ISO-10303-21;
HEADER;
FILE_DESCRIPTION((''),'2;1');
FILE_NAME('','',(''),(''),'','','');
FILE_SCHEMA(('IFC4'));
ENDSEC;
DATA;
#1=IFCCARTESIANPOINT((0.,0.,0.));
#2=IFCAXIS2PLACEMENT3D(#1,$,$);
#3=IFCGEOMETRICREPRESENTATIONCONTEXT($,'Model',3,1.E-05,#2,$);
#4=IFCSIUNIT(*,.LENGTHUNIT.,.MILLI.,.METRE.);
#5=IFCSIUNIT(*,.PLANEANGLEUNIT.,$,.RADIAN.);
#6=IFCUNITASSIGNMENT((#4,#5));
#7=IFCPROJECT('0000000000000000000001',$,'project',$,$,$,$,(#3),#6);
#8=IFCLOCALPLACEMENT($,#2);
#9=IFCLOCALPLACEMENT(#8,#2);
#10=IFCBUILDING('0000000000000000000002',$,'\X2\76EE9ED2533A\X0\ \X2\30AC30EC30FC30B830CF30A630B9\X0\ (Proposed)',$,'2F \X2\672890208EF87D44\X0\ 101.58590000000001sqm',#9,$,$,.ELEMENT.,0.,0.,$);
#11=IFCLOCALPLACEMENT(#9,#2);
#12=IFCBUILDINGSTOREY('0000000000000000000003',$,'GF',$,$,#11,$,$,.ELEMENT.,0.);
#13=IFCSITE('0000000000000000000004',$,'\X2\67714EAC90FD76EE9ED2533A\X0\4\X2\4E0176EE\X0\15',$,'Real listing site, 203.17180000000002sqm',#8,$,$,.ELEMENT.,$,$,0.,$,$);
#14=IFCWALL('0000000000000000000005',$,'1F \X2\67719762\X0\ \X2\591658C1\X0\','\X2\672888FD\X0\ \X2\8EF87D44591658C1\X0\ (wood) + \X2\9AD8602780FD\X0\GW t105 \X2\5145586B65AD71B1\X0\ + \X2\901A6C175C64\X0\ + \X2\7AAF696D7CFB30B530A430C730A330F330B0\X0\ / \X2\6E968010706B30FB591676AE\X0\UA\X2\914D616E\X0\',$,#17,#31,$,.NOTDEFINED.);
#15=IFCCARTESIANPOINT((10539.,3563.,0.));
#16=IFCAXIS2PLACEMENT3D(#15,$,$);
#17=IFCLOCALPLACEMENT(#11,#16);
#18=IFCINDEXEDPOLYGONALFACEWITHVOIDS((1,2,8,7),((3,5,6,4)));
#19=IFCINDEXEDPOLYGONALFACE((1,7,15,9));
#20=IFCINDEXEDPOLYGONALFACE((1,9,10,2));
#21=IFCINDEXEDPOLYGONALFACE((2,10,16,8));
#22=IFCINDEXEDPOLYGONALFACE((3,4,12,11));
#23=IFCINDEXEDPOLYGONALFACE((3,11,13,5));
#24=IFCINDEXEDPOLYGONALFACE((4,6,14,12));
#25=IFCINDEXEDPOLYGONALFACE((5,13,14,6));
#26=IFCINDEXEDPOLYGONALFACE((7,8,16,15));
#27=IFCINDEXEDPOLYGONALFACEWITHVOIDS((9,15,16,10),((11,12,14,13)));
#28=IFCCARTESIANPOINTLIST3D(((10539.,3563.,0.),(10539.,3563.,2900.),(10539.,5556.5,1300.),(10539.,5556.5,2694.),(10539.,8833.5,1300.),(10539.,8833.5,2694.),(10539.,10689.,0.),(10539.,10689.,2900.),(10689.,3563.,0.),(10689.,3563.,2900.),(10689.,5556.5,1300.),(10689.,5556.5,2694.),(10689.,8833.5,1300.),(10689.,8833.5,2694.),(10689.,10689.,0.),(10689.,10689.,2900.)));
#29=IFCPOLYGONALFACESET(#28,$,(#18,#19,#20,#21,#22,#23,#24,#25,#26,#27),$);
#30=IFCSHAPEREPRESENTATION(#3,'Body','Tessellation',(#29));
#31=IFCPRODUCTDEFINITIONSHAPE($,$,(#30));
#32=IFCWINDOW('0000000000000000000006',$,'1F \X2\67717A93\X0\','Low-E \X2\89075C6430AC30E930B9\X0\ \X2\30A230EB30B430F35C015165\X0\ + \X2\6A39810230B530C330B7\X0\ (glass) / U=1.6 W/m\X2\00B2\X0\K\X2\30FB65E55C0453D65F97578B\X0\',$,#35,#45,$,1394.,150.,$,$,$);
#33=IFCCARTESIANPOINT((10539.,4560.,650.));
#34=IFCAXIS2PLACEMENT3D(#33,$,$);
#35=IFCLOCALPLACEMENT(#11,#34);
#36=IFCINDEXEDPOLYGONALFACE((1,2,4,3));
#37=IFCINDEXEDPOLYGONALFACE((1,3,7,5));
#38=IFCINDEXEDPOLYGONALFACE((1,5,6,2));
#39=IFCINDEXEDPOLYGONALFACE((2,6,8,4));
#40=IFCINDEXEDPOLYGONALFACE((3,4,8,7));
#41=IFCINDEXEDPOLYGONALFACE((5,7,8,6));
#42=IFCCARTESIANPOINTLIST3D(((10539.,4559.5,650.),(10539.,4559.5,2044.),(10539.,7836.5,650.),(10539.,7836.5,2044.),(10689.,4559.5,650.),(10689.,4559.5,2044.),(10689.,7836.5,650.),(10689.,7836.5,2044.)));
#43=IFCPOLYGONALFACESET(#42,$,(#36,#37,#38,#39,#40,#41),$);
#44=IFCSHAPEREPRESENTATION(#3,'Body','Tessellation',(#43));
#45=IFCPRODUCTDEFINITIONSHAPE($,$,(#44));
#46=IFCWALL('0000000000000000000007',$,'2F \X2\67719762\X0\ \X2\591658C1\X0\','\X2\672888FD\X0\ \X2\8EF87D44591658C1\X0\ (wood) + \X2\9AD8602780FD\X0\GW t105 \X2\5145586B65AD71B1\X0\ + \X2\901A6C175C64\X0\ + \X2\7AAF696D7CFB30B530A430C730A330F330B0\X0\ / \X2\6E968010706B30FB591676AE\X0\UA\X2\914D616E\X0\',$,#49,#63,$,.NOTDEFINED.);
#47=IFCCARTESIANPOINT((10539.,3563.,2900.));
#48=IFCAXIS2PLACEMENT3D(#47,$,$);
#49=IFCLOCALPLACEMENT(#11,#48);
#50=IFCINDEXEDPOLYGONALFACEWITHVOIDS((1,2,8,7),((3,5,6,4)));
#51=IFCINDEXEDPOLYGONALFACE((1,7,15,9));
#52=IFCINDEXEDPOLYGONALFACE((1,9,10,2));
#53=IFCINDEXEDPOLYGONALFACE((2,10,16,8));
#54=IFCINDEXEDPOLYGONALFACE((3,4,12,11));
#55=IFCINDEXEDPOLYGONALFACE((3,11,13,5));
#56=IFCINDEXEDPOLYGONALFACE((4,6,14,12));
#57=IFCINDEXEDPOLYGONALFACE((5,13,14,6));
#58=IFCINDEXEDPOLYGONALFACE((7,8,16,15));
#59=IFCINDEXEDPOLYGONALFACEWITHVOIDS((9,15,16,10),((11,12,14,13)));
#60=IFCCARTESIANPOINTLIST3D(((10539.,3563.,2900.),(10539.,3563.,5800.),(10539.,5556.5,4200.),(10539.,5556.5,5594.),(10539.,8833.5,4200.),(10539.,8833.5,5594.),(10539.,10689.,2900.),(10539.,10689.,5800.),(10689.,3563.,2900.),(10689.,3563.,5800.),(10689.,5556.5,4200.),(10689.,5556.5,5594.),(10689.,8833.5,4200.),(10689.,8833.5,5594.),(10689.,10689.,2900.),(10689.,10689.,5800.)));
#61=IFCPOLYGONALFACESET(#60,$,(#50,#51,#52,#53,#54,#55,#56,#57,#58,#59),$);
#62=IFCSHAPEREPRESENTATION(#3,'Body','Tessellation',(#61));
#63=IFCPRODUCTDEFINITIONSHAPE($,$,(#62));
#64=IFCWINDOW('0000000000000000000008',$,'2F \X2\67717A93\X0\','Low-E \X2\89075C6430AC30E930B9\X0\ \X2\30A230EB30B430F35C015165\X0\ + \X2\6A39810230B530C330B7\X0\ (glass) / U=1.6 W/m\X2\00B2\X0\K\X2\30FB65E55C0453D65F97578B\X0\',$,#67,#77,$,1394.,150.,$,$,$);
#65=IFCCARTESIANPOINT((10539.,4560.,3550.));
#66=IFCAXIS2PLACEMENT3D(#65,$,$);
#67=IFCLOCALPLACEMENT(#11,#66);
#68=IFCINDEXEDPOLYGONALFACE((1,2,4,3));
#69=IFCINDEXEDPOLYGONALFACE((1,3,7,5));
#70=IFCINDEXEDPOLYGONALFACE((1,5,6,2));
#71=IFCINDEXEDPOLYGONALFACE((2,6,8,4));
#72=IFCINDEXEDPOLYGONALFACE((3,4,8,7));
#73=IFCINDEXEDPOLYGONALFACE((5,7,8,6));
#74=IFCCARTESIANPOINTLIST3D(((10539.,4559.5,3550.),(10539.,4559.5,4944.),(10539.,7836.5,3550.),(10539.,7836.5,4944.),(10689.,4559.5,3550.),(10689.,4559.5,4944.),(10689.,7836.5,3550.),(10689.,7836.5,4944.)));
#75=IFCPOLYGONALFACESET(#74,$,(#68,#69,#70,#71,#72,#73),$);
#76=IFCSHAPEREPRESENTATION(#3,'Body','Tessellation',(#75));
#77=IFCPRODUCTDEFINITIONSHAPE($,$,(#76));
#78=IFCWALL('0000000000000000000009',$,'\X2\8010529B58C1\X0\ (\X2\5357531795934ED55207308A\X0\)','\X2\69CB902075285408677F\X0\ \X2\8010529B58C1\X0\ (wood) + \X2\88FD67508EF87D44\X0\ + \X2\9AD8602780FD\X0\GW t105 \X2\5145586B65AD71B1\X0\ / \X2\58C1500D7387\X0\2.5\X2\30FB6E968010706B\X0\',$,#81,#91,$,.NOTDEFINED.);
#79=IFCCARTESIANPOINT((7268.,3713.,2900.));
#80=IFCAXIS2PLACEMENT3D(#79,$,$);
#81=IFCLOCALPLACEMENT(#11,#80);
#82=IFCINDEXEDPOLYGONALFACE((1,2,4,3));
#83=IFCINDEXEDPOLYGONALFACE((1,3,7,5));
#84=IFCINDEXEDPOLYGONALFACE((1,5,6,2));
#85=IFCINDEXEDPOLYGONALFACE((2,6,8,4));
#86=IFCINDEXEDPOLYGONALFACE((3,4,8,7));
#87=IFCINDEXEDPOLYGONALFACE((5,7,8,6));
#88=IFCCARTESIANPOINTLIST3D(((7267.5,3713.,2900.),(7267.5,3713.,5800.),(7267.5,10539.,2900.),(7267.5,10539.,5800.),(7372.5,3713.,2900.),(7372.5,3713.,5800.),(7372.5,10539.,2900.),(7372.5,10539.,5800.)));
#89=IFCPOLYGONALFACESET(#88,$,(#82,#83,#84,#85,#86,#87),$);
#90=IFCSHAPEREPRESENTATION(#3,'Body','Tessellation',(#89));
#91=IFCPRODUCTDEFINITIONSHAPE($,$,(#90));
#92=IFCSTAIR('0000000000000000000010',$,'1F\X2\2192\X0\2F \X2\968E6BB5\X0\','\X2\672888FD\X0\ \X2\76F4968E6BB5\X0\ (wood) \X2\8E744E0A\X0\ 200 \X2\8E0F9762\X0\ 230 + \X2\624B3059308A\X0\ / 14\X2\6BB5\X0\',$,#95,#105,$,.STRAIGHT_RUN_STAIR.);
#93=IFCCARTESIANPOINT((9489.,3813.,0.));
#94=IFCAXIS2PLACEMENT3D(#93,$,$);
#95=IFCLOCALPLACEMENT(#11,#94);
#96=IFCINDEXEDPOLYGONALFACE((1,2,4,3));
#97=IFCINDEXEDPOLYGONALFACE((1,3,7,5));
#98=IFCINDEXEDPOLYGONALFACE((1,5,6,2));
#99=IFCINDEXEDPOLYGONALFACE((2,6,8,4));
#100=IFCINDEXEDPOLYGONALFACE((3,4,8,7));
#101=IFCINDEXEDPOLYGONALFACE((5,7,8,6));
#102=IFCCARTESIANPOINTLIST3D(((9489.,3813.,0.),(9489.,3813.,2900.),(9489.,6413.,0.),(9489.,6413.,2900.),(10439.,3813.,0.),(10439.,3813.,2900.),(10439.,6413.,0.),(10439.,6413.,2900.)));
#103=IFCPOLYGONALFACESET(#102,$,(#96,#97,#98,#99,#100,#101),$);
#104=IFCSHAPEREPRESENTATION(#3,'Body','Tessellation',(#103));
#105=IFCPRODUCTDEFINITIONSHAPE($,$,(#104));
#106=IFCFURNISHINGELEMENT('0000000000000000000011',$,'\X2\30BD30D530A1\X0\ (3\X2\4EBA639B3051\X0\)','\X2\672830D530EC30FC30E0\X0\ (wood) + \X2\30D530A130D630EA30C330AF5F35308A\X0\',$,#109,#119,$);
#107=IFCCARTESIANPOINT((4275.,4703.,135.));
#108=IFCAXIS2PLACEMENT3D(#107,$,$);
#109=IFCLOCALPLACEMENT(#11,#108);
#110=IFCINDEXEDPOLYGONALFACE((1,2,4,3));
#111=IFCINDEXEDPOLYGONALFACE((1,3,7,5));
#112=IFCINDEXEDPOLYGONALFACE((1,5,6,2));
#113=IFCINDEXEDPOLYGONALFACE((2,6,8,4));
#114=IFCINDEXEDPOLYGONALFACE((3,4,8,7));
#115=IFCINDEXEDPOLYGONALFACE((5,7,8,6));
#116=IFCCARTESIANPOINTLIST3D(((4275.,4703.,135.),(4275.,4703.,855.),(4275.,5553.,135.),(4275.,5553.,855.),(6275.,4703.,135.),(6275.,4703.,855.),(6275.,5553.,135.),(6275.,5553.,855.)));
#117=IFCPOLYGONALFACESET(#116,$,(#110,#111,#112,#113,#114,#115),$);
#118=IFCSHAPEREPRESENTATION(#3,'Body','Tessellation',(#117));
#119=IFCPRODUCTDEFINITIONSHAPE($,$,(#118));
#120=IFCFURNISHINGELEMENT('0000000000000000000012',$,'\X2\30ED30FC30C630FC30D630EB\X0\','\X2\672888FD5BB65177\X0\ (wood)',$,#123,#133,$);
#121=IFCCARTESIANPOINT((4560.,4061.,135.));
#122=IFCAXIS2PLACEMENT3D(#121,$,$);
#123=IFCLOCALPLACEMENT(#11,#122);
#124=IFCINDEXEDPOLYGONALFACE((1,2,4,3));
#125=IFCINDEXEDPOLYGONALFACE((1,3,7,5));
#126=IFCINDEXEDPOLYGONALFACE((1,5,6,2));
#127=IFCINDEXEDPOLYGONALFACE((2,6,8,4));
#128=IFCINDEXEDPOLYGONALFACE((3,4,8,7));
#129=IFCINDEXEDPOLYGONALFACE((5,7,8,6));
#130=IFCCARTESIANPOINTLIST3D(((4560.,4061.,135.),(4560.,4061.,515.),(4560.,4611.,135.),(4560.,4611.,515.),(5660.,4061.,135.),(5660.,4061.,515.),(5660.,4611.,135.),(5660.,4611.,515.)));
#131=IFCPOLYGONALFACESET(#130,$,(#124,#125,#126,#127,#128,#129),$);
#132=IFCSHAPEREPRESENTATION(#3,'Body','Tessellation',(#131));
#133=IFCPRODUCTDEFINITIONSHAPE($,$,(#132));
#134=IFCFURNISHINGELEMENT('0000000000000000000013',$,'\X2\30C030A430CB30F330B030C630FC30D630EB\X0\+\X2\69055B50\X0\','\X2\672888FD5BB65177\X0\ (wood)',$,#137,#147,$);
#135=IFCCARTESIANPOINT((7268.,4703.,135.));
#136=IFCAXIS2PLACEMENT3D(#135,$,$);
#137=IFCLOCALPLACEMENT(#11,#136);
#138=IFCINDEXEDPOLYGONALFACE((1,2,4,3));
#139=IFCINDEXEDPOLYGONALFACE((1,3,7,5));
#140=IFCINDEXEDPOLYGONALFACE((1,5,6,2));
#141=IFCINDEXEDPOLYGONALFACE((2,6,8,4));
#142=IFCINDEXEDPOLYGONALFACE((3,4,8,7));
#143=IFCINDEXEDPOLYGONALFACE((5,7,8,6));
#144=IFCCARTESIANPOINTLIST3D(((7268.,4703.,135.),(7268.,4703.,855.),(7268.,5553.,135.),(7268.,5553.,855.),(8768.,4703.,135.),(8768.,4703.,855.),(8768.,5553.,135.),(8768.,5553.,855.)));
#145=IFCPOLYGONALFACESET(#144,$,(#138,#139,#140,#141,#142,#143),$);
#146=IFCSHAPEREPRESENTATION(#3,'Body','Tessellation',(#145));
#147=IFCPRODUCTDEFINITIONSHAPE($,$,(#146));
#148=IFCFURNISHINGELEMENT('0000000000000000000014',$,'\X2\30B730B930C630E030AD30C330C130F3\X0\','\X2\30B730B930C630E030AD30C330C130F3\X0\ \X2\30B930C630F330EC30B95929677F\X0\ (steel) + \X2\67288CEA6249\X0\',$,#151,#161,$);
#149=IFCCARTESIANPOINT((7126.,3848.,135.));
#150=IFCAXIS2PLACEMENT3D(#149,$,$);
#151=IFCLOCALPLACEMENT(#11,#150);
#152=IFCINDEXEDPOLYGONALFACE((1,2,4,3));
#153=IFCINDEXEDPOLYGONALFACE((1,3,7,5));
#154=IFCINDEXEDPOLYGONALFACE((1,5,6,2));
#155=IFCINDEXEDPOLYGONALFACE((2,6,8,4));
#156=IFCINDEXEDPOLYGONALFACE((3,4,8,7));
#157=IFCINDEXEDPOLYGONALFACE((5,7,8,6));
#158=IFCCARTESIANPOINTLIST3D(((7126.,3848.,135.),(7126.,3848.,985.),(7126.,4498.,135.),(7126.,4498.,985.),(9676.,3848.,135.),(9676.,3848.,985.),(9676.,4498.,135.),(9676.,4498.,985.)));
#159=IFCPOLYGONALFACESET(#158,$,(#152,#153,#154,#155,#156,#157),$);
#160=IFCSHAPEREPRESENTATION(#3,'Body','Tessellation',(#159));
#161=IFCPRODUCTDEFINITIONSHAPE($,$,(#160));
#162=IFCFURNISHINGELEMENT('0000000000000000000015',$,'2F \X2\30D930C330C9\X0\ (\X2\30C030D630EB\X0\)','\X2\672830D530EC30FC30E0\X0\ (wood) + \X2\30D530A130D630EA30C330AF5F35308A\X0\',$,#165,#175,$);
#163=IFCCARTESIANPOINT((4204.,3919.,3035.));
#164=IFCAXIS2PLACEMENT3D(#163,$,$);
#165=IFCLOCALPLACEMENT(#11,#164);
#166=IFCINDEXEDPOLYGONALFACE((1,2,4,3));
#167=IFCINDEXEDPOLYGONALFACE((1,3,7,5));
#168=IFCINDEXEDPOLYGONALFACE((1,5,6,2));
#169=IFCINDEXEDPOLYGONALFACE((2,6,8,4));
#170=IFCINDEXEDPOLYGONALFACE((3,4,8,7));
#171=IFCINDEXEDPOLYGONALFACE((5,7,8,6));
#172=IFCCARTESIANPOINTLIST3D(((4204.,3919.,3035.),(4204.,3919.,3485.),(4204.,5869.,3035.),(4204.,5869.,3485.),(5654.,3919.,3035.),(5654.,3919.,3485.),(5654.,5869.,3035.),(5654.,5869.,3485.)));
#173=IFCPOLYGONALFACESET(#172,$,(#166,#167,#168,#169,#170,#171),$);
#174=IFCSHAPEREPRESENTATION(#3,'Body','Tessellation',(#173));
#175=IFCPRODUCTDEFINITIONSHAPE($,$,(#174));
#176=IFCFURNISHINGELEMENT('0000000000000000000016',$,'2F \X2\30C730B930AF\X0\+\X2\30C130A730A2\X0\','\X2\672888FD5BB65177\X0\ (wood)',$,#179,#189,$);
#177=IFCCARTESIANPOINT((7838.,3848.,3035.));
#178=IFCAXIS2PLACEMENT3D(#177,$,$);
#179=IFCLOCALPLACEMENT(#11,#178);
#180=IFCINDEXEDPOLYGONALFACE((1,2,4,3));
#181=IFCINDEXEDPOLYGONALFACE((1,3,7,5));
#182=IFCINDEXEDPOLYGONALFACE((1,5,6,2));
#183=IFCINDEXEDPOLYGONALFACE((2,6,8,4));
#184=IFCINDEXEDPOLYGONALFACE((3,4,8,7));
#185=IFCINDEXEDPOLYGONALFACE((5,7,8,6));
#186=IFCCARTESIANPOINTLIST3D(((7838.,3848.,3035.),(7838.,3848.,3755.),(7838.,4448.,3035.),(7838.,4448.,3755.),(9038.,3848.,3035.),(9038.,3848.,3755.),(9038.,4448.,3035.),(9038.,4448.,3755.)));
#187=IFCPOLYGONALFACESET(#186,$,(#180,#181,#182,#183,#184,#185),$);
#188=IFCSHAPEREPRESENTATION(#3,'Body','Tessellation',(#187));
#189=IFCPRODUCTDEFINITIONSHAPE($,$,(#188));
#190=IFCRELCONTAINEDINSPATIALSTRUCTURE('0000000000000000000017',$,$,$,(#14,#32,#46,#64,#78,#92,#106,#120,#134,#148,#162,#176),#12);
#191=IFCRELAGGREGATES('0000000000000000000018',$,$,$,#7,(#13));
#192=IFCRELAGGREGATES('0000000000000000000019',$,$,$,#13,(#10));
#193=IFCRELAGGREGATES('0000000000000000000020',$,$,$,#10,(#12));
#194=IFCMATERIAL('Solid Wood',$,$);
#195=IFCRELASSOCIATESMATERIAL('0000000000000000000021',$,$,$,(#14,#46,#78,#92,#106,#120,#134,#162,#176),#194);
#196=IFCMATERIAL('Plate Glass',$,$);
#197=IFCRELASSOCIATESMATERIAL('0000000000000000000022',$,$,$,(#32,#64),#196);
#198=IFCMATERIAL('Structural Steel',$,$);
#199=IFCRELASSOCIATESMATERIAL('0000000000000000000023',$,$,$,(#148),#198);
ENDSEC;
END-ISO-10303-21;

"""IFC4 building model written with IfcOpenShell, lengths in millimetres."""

from ifc_helpers import new_model, si_unit, frame, frame_2d, origin, place, context, project, spatial, rectangle, extrude, material, element, fill, save


model = new_model("IFC4")

# Units and contexts
model_context = context("Model", 3, precision=1e-05, world=origin())
ifc_project = project(units=[si_unit("LENGTHUNIT", "METRE", prefix="MILLI"), si_unit("PLANEANGLEUNIT", "RADIAN")], contexts=[model_context])

# Site, building, storey
site_placement = place(None, origin())
site = spatial("IfcSite", under=ifc_project, at=site_placement, Name="東京都目黒区4丁目15", ObjectType="Real listing site, 203.17180000000002sqm", CompositionType="ELEMENT", RefElevation=0.0)
building_placement = place(site_placement, origin())
building = spatial("IfcBuilding", under=site, at=building_placement, Name="目黒区 ガレージハウス (Proposed)", ObjectType="2F 木造軸組 101.58590000000001sqm", CompositionType="ELEMENT", ElevationOfRefHeight=0.0, ElevationOfTerrain=0.0)
storey_placement = place(building_placement, origin())
storey = spatial("IfcBuildingStorey", under=building, at=storey_placement, Name="GF", CompositionType="ELEMENT", Elevation=0.0)

# Wall, opening, window
ifc_material_1 = material(Name="Solid Wood")
wall_1_placement = place(storey_placement, frame((10539.0, 3563.0, 0.0)))
wall_1 = element("IfcWall", 1, at=wall_1_placement, inside=storey, material=ifc_material_1, Name="1F 東面 外壁", Description="木製 軸組外壁 (wood) + 高性能GW t105 充填断熱 + 通気層 + 窯業系サイディング / 準耐火・外皮UA配慮", PredefinedType="NOTDEFINED", context=model_context, shape_type="SweptSolid", body=[
    extrude(rectangle(XDim=150.0, YDim=7126.0, at=frame_2d((75.0, 3563.0))), frame((10539.0, 3563.0, 0.0)), (0.0, 0.0, 1.0), 2900.0),
])
opening_1_placement = place(storey_placement, frame((10539.0, 4560.0, 650.0)))
opening_1 = element("IfcOpeningElement", 2, at=opening_1_placement, cuts=wall_1, PredefinedType="NOTDEFINED", context=model_context, shape_type="SweptSolid", body=[
    extrude(rectangle(XDim=150.0, YDim=3277.0, at=frame_2d((75.0, 1638.0))), frame((10539.0, 4560.0, 650.0)), (0.0, 0.0, 1.0), 1394.0),
])
ifc_material_2 = material(Name="Plate Glass")
window_1_placement = place(storey_placement, frame((10539.0, 4560.0, 650.0)))
window_1 = element("IfcWindow", 3, at=window_1_placement, inside=storey, material=ifc_material_2, Name="1F 東窓", Description="Low-E 複層ガラス アルゴン封入 + 樹脂サッシ (glass) / U=1.6 W/m²K・日射取得型", OverallHeight=1394.0, OverallWidth=150.0, context=model_context, shape_type="SweptSolid", body=[
    extrude(rectangle(XDim=150.0, YDim=3277.0, at=frame_2d((75.0, 1638.0))), frame((10539.0, 4560.0, 650.0)), (0.0, 0.0, 1.0), 1394.0),
])
fill(opening_1, window_1)

# Wall, opening, window
wall_2_placement = place(storey_placement, frame((10539.0, 3563.0, 2900.0)))
wall_2 = element("IfcWall", 4, at=wall_2_placement, inside=storey, material=ifc_material_1, Name="2F 東面 外壁", Description="木製 軸組外壁 (wood) + 高性能GW t105 充填断熱 + 通気層 + 窯業系サイディング / 準耐火・外皮UA配慮", PredefinedType="NOTDEFINED", context=model_context, shape_type="SweptSolid", body=[
    extrude(rectangle(XDim=150.0, YDim=7126.0, at=frame_2d((75.0, 3563.0))), frame((10539.0, 3563.0, 2900.0)), (0.0, 0.0, 1.0), 2900.0),
])
opening_2_placement = place(storey_placement, frame((10539.0, 4560.0, 3550.0)))
opening_2 = element("IfcOpeningElement", 5, at=opening_2_placement, cuts=wall_2, PredefinedType="NOTDEFINED", context=model_context, shape_type="SweptSolid", body=[
    extrude(rectangle(XDim=150.0, YDim=3277.0, at=frame_2d((75.0, 1638.0))), frame((10539.0, 4560.0, 3550.0)), (0.0, 0.0, 1.0), 1394.0),
])
window_2_placement = place(storey_placement, frame((10539.0, 4560.0, 3550.0)))
window_2 = element("IfcWindow", 6, at=window_2_placement, inside=storey, material=ifc_material_2, Name="2F 東窓", Description="Low-E 複層ガラス アルゴン封入 + 樹脂サッシ (glass) / U=1.6 W/m²K・日射取得型", OverallHeight=1394.0, OverallWidth=150.0, context=model_context, shape_type="SweptSolid", body=[
    extrude(rectangle(XDim=150.0, YDim=3277.0, at=frame_2d((75.0, 1638.0))), frame((10539.0, 4560.0, 3550.0)), (0.0, 0.0, 1.0), 1394.0),
])
fill(opening_2, window_2)

# Wall
wall_3_placement = place(storey_placement, frame((7268.0, 3713.0, 2900.0)))
element("IfcWall", 7, at=wall_3_placement, inside=storey, material=ifc_material_1, Name="耐力壁 (南北間仕切り)", Description="構造用合板 耐力壁 (wood) + 製材軸組 + 高性能GW t105 充填断熱 / 壁倍率2.5・準耐火", PredefinedType="NOTDEFINED", context=model_context, shape_type="SweptSolid", body=[
    extrude(rectangle(XDim=105.0, YDim=6826.0, at=frame_2d((52.0, 3413.0))), frame((7268.0, 3713.0, 2900.0)), (0.0, 0.0, 1.0), 2900.0),
])

# Stair
stair_placement = place(storey_placement, frame((9489.0, 3813.0, 0.0)))
element("IfcStair", 8, at=stair_placement, inside=storey, material=ifc_material_1, Name="1F→2F 階段", Description="木製 直階段 (wood) 蹴上 200 踏面 230 + 手すり / 14段", PredefinedType="STRAIGHT_RUN_STAIR", context=model_context, shape_type="SweptSolid", body=[
    extrude(rectangle(XDim=950.0, YDim=2600.0, at=frame_2d((475.0, 1300.0))), frame((9489.0, 3813.0, 0.0)), (0.0, 0.0, 1.0), 2900.0),
])

# Furnishing elements
furnishing_1_placement = place(storey_placement, frame((4275.0, 4703.0, 135.0)))
element("IfcFurnishingElement", 9, at=furnishing_1_placement, inside=storey, material=ifc_material_1, Name="ソファ (3人掛け)", Description="木フレーム (wood) + ファブリック張り", context=model_context, shape_type="SweptSolid", body=[
    extrude(rectangle(XDim=2000.0, YDim=850.0, at=frame_2d((1000.0, 425.0))), frame((4275.0, 4703.0, 135.0)), (0.0, 0.0, 1.0), 720.0),
])
furnishing_2_placement = place(storey_placement, frame((4560.0, 4061.0, 135.0)))
element("IfcFurnishingElement", 10, at=furnishing_2_placement, inside=storey, material=ifc_material_1, Name="ローテーブル", Description="木製家具 (wood)", context=model_context, shape_type="SweptSolid", body=[
    extrude(rectangle(XDim=1100.0, YDim=550.0, at=frame_2d((550.0, 275.0))), frame((4560.0, 4061.0, 135.0)), (0.0, 0.0, 1.0), 380.0),
])
furnishing_3_placement = place(storey_placement, frame((7268.0, 4703.0, 135.0)))
element("IfcFurnishingElement", 11, at=furnishing_3_placement, inside=storey, material=ifc_material_1, Name="ダイニングテーブル+椅子", Description="木製家具 (wood)", context=model_context, shape_type="SweptSolid", body=[
    extrude(rectangle(XDim=1500.0, YDim=850.0, at=frame_2d((750.0, 425.0))), frame((7268.0, 4703.0, 135.0)), (0.0, 0.0, 1.0), 720.0),
])
ifc_material_3 = material(Name="Structural Steel")
furnishing_4_placement = place(storey_placement, frame((7126.0, 3848.0, 135.0)))
element("IfcFurnishingElement", 12, at=furnishing_4_placement, inside=storey, material=ifc_material_3, Name="システムキッチン", Description="システムキッチン ステンレス天板 (steel) + 木質扉", context=model_context, shape_type="SweptSolid", body=[
    extrude(rectangle(XDim=2550.0, YDim=650.0, at=frame_2d((1275.0, 325.0))), frame((7126.0, 3848.0, 135.0)), (0.0, 0.0, 1.0), 850.0),
])
furnishing_5_placement = place(storey_placement, frame((4204.0, 3919.0, 3035.0)))
element("IfcFurnishingElement", 13, at=furnishing_5_placement, inside=storey, material=ifc_material_1, Name="2F ベッド (ダブル)", Description="木フレーム (wood) + ファブリック張り", context=model_context, shape_type="SweptSolid", body=[
    extrude(rectangle(XDim=1450.0, YDim=1950.0, at=frame_2d((725.0, 975.0))), frame((4204.0, 3919.0, 3035.0)), (0.0, 0.0, 1.0), 450.0),
])
furnishing_6_placement = place(storey_placement, frame((7838.0, 3848.0, 3035.0)))
element("IfcFurnishingElement", 14, at=furnishing_6_placement, inside=storey, material=ifc_material_1, Name="2F デスク+チェア", Description="木製家具 (wood)", context=model_context, shape_type="SweptSolid", body=[
    extrude(rectangle(XDim=1200.0, YDim=600.0, at=frame_2d((600.0, 300.0))), frame((7838.0, 3848.0, 3035.0)), (0.0, 0.0, 1.0), 720.0),
])

save(model, "model.ifc")
